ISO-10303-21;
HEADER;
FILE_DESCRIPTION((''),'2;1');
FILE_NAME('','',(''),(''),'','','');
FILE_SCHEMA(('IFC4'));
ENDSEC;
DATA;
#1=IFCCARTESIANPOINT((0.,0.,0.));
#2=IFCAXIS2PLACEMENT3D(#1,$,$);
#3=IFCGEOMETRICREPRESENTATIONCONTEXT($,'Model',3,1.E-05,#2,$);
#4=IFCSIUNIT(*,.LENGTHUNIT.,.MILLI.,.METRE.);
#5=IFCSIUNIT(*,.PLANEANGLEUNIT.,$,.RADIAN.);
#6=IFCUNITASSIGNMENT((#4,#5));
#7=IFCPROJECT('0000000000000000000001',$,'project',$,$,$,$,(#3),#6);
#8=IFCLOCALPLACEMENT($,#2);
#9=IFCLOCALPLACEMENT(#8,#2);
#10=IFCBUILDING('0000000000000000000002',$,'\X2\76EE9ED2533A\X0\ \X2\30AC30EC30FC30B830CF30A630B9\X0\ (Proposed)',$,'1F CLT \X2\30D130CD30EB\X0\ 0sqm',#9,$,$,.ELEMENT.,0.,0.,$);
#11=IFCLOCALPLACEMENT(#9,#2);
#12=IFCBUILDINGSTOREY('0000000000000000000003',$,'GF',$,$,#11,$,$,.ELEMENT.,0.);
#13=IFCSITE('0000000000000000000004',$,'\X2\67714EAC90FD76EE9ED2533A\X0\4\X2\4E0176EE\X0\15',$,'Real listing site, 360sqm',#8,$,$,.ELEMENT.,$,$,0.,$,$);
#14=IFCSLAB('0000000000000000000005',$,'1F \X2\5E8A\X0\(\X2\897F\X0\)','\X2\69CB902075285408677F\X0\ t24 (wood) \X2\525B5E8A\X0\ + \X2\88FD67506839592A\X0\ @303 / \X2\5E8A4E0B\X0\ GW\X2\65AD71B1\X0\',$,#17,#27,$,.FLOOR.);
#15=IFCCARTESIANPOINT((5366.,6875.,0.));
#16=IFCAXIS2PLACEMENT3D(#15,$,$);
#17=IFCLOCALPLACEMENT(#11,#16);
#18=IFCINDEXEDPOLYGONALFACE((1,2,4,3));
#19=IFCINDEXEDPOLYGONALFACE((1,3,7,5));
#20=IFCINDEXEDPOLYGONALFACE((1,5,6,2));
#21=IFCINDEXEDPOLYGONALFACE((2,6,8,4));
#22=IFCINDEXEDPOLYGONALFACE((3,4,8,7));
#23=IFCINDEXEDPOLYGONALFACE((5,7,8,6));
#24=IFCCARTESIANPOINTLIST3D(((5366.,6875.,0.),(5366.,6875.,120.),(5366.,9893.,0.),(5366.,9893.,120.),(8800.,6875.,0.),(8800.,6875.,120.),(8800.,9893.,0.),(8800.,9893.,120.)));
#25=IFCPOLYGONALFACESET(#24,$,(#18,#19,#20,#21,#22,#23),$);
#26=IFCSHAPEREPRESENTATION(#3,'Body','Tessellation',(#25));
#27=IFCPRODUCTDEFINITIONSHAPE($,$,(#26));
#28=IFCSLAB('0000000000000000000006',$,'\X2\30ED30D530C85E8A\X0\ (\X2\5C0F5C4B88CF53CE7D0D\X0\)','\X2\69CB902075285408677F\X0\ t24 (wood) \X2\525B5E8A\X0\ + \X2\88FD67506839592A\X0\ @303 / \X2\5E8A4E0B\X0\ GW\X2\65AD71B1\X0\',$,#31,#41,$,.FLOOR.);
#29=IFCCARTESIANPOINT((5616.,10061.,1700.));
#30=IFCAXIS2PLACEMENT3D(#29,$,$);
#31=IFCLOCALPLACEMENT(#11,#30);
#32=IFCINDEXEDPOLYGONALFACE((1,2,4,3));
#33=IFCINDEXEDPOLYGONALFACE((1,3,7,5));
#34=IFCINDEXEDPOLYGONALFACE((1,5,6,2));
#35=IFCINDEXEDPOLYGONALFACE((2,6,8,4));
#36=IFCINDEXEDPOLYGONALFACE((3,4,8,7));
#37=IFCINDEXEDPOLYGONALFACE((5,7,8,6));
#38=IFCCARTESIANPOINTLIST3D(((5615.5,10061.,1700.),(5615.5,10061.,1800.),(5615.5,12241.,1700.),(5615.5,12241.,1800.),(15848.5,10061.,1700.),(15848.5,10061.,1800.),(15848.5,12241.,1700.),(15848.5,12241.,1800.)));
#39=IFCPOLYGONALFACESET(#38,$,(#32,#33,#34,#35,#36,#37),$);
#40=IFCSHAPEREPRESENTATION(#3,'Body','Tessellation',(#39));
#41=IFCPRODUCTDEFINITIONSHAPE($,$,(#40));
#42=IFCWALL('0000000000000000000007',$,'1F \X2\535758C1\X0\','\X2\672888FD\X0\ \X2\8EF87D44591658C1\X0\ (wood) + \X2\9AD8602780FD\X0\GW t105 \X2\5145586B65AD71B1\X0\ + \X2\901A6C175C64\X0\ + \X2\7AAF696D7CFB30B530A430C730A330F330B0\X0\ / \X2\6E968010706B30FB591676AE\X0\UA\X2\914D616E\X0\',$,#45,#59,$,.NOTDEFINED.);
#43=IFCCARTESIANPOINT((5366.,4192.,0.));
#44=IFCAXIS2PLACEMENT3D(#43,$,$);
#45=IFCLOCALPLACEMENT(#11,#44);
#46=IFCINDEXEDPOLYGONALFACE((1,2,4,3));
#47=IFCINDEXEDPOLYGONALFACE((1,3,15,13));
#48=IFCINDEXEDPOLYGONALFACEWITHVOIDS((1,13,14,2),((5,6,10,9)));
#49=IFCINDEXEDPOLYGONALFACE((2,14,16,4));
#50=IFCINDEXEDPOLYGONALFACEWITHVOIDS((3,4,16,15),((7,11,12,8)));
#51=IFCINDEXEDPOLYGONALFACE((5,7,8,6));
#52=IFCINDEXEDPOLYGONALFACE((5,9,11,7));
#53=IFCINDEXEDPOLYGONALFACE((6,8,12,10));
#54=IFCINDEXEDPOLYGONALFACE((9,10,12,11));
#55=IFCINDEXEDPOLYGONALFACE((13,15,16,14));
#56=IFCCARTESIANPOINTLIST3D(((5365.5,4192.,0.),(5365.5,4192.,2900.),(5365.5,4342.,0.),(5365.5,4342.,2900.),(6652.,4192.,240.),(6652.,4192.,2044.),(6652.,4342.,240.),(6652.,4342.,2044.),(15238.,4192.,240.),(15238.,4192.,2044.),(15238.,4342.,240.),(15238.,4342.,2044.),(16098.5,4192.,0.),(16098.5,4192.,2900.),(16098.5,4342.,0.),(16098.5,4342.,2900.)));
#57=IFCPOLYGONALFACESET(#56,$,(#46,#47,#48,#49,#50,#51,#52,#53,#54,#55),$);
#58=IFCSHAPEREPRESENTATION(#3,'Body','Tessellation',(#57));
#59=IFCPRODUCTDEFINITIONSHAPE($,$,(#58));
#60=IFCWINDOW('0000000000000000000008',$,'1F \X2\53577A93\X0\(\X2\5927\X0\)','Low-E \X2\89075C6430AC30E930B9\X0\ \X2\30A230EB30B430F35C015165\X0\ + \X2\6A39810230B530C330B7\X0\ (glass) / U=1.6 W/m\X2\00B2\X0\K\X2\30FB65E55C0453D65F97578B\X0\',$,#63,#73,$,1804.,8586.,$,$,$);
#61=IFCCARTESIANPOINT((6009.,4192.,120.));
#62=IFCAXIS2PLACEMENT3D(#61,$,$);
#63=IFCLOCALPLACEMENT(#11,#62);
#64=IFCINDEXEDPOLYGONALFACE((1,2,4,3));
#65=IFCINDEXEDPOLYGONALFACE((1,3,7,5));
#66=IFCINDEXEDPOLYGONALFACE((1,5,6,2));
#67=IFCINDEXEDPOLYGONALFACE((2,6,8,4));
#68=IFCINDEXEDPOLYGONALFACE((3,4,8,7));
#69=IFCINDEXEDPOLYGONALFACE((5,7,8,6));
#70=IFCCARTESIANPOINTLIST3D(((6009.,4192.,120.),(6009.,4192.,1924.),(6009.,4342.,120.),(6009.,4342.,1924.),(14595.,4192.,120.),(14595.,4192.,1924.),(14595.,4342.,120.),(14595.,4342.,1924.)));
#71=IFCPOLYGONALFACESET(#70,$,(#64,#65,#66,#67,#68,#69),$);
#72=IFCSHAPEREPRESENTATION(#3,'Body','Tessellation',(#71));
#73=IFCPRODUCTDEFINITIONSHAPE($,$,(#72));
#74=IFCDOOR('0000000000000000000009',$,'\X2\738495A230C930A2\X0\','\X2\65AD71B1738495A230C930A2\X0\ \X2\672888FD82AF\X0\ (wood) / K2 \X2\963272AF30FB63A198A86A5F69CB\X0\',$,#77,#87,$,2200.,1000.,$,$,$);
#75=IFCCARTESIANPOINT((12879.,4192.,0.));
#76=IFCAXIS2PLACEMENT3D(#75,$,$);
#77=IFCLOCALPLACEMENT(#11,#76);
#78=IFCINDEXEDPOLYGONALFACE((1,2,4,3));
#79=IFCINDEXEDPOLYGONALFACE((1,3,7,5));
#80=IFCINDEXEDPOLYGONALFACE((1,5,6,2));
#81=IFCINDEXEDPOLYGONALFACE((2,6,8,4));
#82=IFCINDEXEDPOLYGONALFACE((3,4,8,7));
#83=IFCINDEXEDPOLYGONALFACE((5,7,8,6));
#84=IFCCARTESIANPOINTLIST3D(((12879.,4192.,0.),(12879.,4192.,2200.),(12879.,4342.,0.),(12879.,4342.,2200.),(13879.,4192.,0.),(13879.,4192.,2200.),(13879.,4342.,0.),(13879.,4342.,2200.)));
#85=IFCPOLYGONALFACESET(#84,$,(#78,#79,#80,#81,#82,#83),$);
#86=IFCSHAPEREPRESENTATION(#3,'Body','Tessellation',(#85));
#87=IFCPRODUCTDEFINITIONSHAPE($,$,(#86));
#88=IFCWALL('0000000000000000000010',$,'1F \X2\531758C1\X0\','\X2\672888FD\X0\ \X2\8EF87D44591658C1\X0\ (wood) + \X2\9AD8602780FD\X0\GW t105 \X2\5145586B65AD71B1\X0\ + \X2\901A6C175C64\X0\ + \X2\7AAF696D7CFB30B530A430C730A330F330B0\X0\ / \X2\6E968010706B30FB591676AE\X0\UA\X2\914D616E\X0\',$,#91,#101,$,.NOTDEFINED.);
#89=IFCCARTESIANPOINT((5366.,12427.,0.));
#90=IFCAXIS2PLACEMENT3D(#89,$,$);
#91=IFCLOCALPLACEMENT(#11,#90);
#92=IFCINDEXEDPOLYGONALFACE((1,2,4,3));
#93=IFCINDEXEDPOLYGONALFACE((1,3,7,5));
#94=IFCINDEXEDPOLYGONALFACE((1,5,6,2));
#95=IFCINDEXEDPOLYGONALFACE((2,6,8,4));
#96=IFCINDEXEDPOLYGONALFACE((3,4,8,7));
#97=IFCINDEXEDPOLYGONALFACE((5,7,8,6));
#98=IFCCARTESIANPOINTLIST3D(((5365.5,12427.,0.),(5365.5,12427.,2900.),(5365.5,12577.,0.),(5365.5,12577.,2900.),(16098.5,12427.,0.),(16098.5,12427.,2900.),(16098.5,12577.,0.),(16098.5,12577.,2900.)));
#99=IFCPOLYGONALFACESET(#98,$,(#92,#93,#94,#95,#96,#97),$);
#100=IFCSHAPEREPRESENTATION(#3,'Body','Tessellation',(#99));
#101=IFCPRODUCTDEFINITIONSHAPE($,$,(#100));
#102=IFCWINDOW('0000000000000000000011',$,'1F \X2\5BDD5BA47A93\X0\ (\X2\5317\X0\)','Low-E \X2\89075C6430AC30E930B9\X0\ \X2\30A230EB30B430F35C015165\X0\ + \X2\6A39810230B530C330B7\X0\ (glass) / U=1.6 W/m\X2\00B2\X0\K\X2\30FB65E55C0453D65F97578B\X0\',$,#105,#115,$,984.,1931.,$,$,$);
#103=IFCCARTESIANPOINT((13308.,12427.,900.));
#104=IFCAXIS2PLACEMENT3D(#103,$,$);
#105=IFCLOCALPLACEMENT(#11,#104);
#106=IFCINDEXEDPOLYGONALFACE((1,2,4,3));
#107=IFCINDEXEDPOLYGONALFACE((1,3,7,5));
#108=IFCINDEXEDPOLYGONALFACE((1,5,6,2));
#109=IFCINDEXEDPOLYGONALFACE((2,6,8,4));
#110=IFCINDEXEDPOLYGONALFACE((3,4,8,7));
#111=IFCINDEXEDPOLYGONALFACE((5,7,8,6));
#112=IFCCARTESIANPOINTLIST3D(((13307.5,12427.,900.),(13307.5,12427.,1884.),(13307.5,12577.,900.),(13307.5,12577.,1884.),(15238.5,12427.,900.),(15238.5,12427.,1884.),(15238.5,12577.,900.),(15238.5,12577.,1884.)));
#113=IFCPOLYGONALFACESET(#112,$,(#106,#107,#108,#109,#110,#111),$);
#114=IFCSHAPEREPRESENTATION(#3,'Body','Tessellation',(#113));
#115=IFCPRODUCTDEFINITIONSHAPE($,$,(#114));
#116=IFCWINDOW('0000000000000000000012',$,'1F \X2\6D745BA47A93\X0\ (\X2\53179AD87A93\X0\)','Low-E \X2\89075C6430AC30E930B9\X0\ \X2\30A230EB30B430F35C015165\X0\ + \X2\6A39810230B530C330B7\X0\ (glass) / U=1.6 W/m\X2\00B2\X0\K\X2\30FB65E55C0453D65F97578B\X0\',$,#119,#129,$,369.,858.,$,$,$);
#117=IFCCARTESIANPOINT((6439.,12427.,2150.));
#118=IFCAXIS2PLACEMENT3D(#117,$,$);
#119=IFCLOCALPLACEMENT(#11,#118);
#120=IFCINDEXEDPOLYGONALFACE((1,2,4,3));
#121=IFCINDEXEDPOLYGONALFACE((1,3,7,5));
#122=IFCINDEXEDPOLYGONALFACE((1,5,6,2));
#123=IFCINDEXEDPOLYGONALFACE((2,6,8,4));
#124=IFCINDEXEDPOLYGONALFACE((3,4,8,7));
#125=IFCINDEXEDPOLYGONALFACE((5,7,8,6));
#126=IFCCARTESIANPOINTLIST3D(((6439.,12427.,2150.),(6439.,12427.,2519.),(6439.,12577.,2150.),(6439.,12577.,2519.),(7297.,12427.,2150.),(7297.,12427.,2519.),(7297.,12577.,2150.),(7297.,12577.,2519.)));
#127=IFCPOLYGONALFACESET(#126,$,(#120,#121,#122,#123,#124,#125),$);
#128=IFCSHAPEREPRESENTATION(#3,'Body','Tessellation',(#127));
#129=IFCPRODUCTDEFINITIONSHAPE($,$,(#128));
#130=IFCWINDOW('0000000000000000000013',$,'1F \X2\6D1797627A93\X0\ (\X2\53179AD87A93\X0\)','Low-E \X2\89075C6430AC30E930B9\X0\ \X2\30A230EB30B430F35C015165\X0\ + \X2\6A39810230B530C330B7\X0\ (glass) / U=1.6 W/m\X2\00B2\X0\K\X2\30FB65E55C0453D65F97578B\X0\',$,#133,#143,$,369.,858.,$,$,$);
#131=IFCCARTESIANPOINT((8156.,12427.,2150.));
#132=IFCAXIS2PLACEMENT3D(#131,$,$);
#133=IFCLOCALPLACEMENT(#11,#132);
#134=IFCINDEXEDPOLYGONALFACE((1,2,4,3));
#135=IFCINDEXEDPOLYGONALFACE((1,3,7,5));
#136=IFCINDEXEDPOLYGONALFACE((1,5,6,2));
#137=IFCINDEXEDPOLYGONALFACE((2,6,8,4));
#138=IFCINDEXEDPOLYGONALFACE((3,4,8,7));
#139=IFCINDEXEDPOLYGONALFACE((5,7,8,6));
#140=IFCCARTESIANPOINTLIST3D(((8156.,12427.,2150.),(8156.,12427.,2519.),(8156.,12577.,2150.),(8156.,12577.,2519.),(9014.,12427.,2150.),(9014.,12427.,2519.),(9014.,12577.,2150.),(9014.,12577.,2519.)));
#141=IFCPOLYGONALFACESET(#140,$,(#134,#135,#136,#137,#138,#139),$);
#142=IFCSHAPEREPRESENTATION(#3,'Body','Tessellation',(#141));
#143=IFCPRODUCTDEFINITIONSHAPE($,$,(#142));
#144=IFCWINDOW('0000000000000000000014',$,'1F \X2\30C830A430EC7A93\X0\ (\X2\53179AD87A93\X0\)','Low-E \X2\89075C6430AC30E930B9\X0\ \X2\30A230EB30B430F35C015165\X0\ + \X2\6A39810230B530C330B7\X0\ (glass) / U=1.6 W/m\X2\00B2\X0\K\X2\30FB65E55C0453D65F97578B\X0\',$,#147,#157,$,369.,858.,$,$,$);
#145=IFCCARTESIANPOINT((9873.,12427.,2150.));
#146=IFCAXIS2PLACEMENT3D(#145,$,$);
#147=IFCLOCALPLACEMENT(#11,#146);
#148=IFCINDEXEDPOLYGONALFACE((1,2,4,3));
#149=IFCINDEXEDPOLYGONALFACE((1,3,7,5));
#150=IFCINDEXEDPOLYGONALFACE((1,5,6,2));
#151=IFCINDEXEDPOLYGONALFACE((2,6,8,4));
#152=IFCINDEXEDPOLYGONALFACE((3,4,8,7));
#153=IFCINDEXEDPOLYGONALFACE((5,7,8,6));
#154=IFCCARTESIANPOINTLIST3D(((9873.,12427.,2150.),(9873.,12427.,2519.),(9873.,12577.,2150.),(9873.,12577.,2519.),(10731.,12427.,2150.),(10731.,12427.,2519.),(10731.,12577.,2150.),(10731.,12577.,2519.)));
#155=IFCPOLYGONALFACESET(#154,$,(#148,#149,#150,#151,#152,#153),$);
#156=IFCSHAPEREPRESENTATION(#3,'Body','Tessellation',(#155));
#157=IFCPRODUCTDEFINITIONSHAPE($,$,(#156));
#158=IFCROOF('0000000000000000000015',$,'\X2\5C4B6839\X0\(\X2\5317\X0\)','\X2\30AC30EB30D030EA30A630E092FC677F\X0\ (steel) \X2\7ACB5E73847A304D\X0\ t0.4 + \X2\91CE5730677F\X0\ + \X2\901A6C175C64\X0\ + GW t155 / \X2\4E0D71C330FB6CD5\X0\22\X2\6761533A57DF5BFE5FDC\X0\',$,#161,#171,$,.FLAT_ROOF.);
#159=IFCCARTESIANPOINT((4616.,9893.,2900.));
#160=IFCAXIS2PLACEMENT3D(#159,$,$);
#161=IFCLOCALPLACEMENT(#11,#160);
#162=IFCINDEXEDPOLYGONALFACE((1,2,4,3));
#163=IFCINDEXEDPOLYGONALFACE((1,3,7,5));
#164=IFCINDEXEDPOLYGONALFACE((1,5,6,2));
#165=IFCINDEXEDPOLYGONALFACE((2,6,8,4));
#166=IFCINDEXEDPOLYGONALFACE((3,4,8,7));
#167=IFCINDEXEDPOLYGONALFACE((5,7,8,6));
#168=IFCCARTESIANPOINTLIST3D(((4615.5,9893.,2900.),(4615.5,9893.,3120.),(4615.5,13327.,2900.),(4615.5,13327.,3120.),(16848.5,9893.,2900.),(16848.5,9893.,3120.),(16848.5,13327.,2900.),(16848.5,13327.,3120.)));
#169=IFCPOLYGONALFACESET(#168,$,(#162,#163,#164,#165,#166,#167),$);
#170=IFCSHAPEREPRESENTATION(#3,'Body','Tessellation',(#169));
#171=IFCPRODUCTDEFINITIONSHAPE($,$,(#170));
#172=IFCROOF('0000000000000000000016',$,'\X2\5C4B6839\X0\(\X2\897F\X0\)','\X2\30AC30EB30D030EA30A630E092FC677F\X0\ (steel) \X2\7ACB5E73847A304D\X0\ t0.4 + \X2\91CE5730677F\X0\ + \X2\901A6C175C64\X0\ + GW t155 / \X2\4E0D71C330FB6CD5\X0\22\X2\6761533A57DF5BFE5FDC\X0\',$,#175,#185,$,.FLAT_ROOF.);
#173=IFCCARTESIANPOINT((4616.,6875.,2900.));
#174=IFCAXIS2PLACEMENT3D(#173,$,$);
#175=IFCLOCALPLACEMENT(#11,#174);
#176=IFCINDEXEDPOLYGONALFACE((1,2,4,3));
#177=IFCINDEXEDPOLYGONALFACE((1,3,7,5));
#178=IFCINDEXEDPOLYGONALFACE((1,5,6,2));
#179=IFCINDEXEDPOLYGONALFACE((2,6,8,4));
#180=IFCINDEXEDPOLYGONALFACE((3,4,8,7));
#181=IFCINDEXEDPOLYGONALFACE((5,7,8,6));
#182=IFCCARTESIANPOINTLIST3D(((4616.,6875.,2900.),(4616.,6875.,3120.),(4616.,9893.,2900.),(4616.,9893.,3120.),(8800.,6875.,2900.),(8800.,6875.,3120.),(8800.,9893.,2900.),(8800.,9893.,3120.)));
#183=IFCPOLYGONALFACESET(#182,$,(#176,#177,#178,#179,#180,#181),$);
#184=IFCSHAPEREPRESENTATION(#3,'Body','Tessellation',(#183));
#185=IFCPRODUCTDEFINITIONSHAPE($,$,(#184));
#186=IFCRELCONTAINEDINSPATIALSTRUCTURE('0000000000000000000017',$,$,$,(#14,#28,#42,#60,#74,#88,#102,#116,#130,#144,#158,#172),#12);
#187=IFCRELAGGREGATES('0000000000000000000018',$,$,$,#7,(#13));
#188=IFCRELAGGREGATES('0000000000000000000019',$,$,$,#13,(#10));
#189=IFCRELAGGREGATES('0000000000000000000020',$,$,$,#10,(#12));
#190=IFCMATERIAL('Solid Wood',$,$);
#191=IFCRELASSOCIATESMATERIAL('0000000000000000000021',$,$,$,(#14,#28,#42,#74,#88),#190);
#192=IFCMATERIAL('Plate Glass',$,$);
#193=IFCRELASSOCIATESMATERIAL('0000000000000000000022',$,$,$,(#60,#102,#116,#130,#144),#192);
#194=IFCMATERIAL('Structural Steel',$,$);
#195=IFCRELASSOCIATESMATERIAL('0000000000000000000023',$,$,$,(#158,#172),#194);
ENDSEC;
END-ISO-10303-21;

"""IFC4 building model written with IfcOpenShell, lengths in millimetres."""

from ifc_helpers import new_model, si_unit, frame, frame_2d, origin, place, context, project, spatial, rectangle, extrude, material, element, fill, save


model = new_model("IFC4")

# Units and contexts
model_context = context("Model", 3, precision=1e-05, world=origin())
ifc_project = project(units=[si_unit("LENGTHUNIT", "METRE", prefix="MILLI"), si_unit("PLANEANGLEUNIT", "RADIAN")], contexts=[model_context])

# Site, building, storey
site_placement = place(None, origin())
site = spatial("IfcSite", under=ifc_project, at=site_placement, Name="東京都目黒区4丁目15", ObjectType="Real listing site, 360sqm", CompositionType="ELEMENT", RefElevation=0.0)
building_placement = place(site_placement, origin())
building = spatial("IfcBuilding", under=site, at=building_placement, Name="目黒区 ガレージハウス (Proposed)", ObjectType="1F CLT パネル 0sqm", CompositionType="ELEMENT", ElevationOfRefHeight=0.0, ElevationOfTerrain=0.0)
storey_placement = place(building_placement, origin())
storey = spatial("IfcBuildingStorey", under=building, at=storey_placement, Name="GF", CompositionType="ELEMENT", Elevation=0.0)

# Slabs
ifc_material_1 = material(Name="Solid Wood")
slab_1_placement = place(storey_placement, frame((5366.0, 6875.0, 0.0)))
element("IfcSlab", 1, at=slab_1_placement, inside=storey, material=ifc_material_1, Name="1F 床(西)", Description="構造用合板 t24 (wood) 剛床 + 製材根太 @303 / 床下 GW断熱", PredefinedType="FLOOR", context=model_context, shape_type="SweptSolid", body=[
    extrude(rectangle(XDim=3434.0, YDim=3018.0, at=frame_2d((1717.0, 1509.0))), frame((5366.0, 6875.0, 0.0)), (0.0, 0.0, 1.0), 120.0),
])
slab_2_placement = place(storey_placement, frame((5616.0, 10061.0, 1700.0)))
element("IfcSlab", 2, at=slab_2_placement, inside=storey, material=ifc_material_1, Name="ロフト床 (小屋裏収納)", Description="構造用合板 t24 (wood) 剛床 + 製材根太 @303 / 床下 GW断熱", PredefinedType="FLOOR", context=model_context, shape_type="SweptSolid", body=[
    extrude(rectangle(XDim=10233.0, YDim=2180.0, at=frame_2d((5116.0, 1090.0))), frame((5616.0, 10061.0, 1700.0)), (0.0, 0.0, 1.0), 100.0),
])

# Wall, openings, window, door
wall_1_placement = place(storey_placement, frame((5366.0, 4192.0, 0.0)))
wall_1 = element("IfcWall", 3, at=wall_1_placement, inside=storey, material=ifc_material_1, Name="1F 南壁", Description="木製 軸組外壁 (wood) + 高性能GW t105 充填断熱 + 通気層 + 窯業系サイディング / 準耐火・外皮UA配慮", PredefinedType="NOTDEFINED", context=model_context, shape_type="SweptSolid", body=[
    extrude(rectangle(XDim=10733.0, YDim=150.0, at=frame_2d((5366.0, 75.0))), frame((5366.0, 4192.0, 0.0)), (0.0, 0.0, 1.0), 2900.0),
])
opening_1_placement = place(storey_placement, frame((6009.0, 4192.0, 120.0)))
opening_1 = element("IfcOpeningElement", 4, at=opening_1_placement, cuts=wall_1, PredefinedType="NOTDEFINED", context=model_context, shape_type="SweptSolid", body=[
    extrude(rectangle(XDim=8586.0, YDim=150.0, at=frame_2d((4293.0, 75.0))), frame((6009.0, 4192.0, 120.0)), (0.0, 0.0, 1.0), 1804.0),
])
opening_2_placement = place(storey_placement, frame((12879.0, 4192.0, 0.0)))
opening_2 = element("IfcOpeningElement", 5, at=opening_2_placement, cuts=wall_1, PredefinedType="NOTDEFINED", context=model_context, shape_type="SweptSolid", body=[
    extrude(rectangle(XDim=1000.0, YDim=150.0, at=frame_2d((500.0, 75.0))), frame((12879.0, 4192.0, 0.0)), (0.0, 0.0, 1.0), 2200.0),
])
ifc_material_2 = material(Name="Plate Glass")
window_1_placement = place(storey_placement, frame((6009.0, 4192.0, 120.0)))
window_1 = element("IfcWindow", 6, at=window_1_placement, inside=storey, material=ifc_material_2, Name="1F 南窓(大)", Description="Low-E 複層ガラス アルゴン封入 + 樹脂サッシ (glass) / U=1.6 W/m²K・日射取得型", OverallHeight=1804.0, OverallWidth=8586.0, context=model_context, shape_type="SweptSolid", body=[
    extrude(rectangle(XDim=8586.0, YDim=150.0, at=frame_2d((4293.0, 75.0))), frame((6009.0, 4192.0, 120.0)), (0.0, 0.0, 1.0), 1804.0),
])
fill(opening_1, window_1)
door_1_placement = place(storey_placement, frame((12879.0, 4192.0, 0.0)))
door_1 = element("IfcDoor", 7, at=door_1_placement, inside=storey, material=ifc_material_1, Name="玄関ドア", Description="断熱玄関ドア 木製芯 (wood) / K2 防犯・採風機構", OverallHeight=2200.0, OverallWidth=1000.0, context=model_context, shape_type="SweptSolid", body=[
    extrude(rectangle(XDim=1000.0, YDim=150.0, at=frame_2d((500.0, 75.0))), frame((12879.0, 4192.0, 0.0)), (0.0, 0.0, 1.0), 2200.0),
])
fill(opening_2, door_1)

# Wall, openings, windows
wall_2_placement = place(storey_placement, frame((5366.0, 12427.0, 0.0)))
wall_2 = element("IfcWall", 8, at=wall_2_placement, inside=storey, material=ifc_material_1, Name="1F 北壁", Description="木製 軸組外壁 (wood) + 高性能GW t105 充填断熱 + 通気層 + 窯業系サイディング / 準耐火・外皮UA配慮", PredefinedType="NOTDEFINED", context=model_context, shape_type="SweptSolid", body=[
    extrude(rectangle(XDim=10733.0, YDim=150.0, at=frame_2d((5366.0, 75.0))), frame((5366.0, 12427.0, 0.0)), (0.0, 0.0, 1.0), 2900.0),
])
opening_3_placement = place(storey_placement, frame((13308.0, 12427.0, 900.0)))
opening_3 = element("IfcOpeningElement", 9, at=opening_3_placement, cuts=wall_2, PredefinedType="NOTDEFINED", context=model_context, shape_type="SweptSolid", body=[
    extrude(rectangle(XDim=1931.0, YDim=150.0, at=frame_2d((965.0, 75.0))), frame((13308.0, 12427.0, 900.0)), (0.0, 0.0, 1.0), 984.0),
])
opening_4_placement = place(storey_placement, frame((6439.0, 12427.0, 2150.0)))
opening_4 = element("IfcOpeningElement", 10, at=opening_4_placement, cuts=wall_2, PredefinedType="NOTDEFINED", context=model_context, shape_type="SweptSolid", body=[
    extrude(rectangle(XDim=858.0, YDim=150.0, at=frame_2d((429.0, 75.0))), frame((6439.0, 12427.0, 2150.0)), (0.0, 0.0, 1.0), 369.0),
])
opening_5_placement = place(storey_placement, frame((8156.0, 12427.0, 2150.0)))
opening_5 = element("IfcOpeningElement", 11, at=opening_5_placement, cuts=wall_2, PredefinedType="NOTDEFINED", context=model_context, shape_type="SweptSolid", body=[
    extrude(rectangle(XDim=858.0, YDim=150.0, at=frame_2d((429.0, 75.0))), frame((8156.0, 12427.0, 2150.0)), (0.0, 0.0, 1.0), 369.0),
])
opening_6_placement = place(storey_placement, frame((9873.0, 12427.0, 2150.0)))
opening_6 = element("IfcOpeningElement", 12, at=opening_6_placement, cuts=wall_2, PredefinedType="NOTDEFINED", context=model_context, shape_type="SweptSolid", body=[
    extrude(rectangle(XDim=858.0, YDim=150.0, at=frame_2d((429.0, 75.0))), frame((9873.0, 12427.0, 2150.0)), (0.0, 0.0, 1.0), 369.0),
])
window_2_placement = place(storey_placement, frame((13308.0, 12427.0, 900.0)))
window_2 = element("IfcWindow", 13, at=window_2_placement, inside=storey, material=ifc_material_2, Name="1F 寝室窓 (北)", Description="Low-E 複層ガラス アルゴン封入 + 樹脂サッシ (glass) / U=1.6 W/m²K・日射取得型", OverallHeight=984.0, OverallWidth=1931.0, context=model_context, shape_type="SweptSolid", body=[
    extrude(rectangle(XDim=1931.0, YDim=150.0, at=frame_2d((965.0, 75.0))), frame((13308.0, 12427.0, 900.0)), (0.0, 0.0, 1.0), 984.0),
])
fill(opening_3, window_2)
window_3_placement = place(storey_placement, frame((6439.0, 12427.0, 2150.0)))
window_3 = element("IfcWindow", 14, at=window_3_placement, inside=storey, material=ifc_material_2, Name="1F 浴室窓 (北高窓)", Description="Low-E 複層ガラス アルゴン封入 + 樹脂サッシ (glass) / U=1.6 W/m²K・日射取得型", OverallHeight=369.0, OverallWidth=858.0, context=model_context, shape_type="SweptSolid", body=[
    extrude(rectangle(XDim=858.0, YDim=150.0, at=frame_2d((429.0, 75.0))), frame((6439.0, 12427.0, 2150.0)), (0.0, 0.0, 1.0), 369.0),
])
fill(opening_4, window_3)
window_4_placement = place(storey_placement, frame((8156.0, 12427.0, 2150.0)))
window_4 = element("IfcWindow", 15, at=window_4_placement, inside=storey, material=ifc_material_2, Name="1F 洗面窓 (北高窓)", Description="Low-E 複層ガラス アルゴン封入 + 樹脂サッシ (glass) / U=1.6 W/m²K・日射取得型", OverallHeight=369.0, OverallWidth=858.0, context=model_context, shape_type="SweptSolid", body=[
    extrude(rectangle(XDim=858.0, YDim=150.0, at=frame_2d((429.0, 75.0))), frame((8156.0, 12427.0, 2150.0)), (0.0, 0.0, 1.0), 369.0),
])
fill(opening_5, window_4)
window_5_placement = place(storey_placement, frame((9873.0, 12427.0, 2150.0)))
window_5 = element("IfcWindow", 16, at=window_5_placement, inside=storey, material=ifc_material_2, Name="1F トイレ窓 (北高窓)", Description="Low-E 複層ガラス アルゴン封入 + 樹脂サッシ (glass) / U=1.6 W/m²K・日射取得型", OverallHeight=369.0, OverallWidth=858.0, context=model_context, shape_type="SweptSolid", body=[
    extrude(rectangle(XDim=858.0, YDim=150.0, at=frame_2d((429.0, 75.0))), frame((9873.0, 12427.0, 2150.0)), (0.0, 0.0, 1.0), 369.0),
])
fill(opening_6, window_5)

# Roofs
ifc_material_3 = material(Name="Structural Steel")
roof_1_placement = place(storey_placement, frame((4616.0, 9893.0, 2900.0)))
element("IfcRoof", 17, at=roof_1_placement, inside=storey, material=ifc_material_3, Name="屋根(北)", Description="ガルバリウム鋼板 (steel) 立平葺き t0.4 + 野地板 + 通気層 + GW t155 / 不燃・法22条区域対応", PredefinedType="FLAT_ROOF", context=model_context, shape_type="SweptSolid", body=[
    extrude(rectangle(XDim=12233.0, YDim=3434.0, at=frame_2d((6116.0, 1717.0))), frame((4616.0, 9893.0, 2900.0)), (0.0, 0.0, 1.0), 220.0),
])
roof_2_placement = place(storey_placement, frame((4616.0, 6875.0, 2900.0)))
element("IfcRoof", 18, at=roof_2_placement, inside=storey, material=ifc_material_3, Name="屋根(西)", Description="ガルバリウム鋼板 (steel) 立平葺き t0.4 + 野地板 + 通気層 + GW t155 / 不燃・法22条区域対応", PredefinedType="FLAT_ROOF", context=model_context, shape_type="SweptSolid", body=[
    extrude(rectangle(XDim=4184.0, YDim=3018.0, at=frame_2d((2092.0, 1509.0))), frame((4616.0, 6875.0, 2900.0)), (0.0, 0.0, 1.0), 220.0),
])

save(model, "model.ifc")
